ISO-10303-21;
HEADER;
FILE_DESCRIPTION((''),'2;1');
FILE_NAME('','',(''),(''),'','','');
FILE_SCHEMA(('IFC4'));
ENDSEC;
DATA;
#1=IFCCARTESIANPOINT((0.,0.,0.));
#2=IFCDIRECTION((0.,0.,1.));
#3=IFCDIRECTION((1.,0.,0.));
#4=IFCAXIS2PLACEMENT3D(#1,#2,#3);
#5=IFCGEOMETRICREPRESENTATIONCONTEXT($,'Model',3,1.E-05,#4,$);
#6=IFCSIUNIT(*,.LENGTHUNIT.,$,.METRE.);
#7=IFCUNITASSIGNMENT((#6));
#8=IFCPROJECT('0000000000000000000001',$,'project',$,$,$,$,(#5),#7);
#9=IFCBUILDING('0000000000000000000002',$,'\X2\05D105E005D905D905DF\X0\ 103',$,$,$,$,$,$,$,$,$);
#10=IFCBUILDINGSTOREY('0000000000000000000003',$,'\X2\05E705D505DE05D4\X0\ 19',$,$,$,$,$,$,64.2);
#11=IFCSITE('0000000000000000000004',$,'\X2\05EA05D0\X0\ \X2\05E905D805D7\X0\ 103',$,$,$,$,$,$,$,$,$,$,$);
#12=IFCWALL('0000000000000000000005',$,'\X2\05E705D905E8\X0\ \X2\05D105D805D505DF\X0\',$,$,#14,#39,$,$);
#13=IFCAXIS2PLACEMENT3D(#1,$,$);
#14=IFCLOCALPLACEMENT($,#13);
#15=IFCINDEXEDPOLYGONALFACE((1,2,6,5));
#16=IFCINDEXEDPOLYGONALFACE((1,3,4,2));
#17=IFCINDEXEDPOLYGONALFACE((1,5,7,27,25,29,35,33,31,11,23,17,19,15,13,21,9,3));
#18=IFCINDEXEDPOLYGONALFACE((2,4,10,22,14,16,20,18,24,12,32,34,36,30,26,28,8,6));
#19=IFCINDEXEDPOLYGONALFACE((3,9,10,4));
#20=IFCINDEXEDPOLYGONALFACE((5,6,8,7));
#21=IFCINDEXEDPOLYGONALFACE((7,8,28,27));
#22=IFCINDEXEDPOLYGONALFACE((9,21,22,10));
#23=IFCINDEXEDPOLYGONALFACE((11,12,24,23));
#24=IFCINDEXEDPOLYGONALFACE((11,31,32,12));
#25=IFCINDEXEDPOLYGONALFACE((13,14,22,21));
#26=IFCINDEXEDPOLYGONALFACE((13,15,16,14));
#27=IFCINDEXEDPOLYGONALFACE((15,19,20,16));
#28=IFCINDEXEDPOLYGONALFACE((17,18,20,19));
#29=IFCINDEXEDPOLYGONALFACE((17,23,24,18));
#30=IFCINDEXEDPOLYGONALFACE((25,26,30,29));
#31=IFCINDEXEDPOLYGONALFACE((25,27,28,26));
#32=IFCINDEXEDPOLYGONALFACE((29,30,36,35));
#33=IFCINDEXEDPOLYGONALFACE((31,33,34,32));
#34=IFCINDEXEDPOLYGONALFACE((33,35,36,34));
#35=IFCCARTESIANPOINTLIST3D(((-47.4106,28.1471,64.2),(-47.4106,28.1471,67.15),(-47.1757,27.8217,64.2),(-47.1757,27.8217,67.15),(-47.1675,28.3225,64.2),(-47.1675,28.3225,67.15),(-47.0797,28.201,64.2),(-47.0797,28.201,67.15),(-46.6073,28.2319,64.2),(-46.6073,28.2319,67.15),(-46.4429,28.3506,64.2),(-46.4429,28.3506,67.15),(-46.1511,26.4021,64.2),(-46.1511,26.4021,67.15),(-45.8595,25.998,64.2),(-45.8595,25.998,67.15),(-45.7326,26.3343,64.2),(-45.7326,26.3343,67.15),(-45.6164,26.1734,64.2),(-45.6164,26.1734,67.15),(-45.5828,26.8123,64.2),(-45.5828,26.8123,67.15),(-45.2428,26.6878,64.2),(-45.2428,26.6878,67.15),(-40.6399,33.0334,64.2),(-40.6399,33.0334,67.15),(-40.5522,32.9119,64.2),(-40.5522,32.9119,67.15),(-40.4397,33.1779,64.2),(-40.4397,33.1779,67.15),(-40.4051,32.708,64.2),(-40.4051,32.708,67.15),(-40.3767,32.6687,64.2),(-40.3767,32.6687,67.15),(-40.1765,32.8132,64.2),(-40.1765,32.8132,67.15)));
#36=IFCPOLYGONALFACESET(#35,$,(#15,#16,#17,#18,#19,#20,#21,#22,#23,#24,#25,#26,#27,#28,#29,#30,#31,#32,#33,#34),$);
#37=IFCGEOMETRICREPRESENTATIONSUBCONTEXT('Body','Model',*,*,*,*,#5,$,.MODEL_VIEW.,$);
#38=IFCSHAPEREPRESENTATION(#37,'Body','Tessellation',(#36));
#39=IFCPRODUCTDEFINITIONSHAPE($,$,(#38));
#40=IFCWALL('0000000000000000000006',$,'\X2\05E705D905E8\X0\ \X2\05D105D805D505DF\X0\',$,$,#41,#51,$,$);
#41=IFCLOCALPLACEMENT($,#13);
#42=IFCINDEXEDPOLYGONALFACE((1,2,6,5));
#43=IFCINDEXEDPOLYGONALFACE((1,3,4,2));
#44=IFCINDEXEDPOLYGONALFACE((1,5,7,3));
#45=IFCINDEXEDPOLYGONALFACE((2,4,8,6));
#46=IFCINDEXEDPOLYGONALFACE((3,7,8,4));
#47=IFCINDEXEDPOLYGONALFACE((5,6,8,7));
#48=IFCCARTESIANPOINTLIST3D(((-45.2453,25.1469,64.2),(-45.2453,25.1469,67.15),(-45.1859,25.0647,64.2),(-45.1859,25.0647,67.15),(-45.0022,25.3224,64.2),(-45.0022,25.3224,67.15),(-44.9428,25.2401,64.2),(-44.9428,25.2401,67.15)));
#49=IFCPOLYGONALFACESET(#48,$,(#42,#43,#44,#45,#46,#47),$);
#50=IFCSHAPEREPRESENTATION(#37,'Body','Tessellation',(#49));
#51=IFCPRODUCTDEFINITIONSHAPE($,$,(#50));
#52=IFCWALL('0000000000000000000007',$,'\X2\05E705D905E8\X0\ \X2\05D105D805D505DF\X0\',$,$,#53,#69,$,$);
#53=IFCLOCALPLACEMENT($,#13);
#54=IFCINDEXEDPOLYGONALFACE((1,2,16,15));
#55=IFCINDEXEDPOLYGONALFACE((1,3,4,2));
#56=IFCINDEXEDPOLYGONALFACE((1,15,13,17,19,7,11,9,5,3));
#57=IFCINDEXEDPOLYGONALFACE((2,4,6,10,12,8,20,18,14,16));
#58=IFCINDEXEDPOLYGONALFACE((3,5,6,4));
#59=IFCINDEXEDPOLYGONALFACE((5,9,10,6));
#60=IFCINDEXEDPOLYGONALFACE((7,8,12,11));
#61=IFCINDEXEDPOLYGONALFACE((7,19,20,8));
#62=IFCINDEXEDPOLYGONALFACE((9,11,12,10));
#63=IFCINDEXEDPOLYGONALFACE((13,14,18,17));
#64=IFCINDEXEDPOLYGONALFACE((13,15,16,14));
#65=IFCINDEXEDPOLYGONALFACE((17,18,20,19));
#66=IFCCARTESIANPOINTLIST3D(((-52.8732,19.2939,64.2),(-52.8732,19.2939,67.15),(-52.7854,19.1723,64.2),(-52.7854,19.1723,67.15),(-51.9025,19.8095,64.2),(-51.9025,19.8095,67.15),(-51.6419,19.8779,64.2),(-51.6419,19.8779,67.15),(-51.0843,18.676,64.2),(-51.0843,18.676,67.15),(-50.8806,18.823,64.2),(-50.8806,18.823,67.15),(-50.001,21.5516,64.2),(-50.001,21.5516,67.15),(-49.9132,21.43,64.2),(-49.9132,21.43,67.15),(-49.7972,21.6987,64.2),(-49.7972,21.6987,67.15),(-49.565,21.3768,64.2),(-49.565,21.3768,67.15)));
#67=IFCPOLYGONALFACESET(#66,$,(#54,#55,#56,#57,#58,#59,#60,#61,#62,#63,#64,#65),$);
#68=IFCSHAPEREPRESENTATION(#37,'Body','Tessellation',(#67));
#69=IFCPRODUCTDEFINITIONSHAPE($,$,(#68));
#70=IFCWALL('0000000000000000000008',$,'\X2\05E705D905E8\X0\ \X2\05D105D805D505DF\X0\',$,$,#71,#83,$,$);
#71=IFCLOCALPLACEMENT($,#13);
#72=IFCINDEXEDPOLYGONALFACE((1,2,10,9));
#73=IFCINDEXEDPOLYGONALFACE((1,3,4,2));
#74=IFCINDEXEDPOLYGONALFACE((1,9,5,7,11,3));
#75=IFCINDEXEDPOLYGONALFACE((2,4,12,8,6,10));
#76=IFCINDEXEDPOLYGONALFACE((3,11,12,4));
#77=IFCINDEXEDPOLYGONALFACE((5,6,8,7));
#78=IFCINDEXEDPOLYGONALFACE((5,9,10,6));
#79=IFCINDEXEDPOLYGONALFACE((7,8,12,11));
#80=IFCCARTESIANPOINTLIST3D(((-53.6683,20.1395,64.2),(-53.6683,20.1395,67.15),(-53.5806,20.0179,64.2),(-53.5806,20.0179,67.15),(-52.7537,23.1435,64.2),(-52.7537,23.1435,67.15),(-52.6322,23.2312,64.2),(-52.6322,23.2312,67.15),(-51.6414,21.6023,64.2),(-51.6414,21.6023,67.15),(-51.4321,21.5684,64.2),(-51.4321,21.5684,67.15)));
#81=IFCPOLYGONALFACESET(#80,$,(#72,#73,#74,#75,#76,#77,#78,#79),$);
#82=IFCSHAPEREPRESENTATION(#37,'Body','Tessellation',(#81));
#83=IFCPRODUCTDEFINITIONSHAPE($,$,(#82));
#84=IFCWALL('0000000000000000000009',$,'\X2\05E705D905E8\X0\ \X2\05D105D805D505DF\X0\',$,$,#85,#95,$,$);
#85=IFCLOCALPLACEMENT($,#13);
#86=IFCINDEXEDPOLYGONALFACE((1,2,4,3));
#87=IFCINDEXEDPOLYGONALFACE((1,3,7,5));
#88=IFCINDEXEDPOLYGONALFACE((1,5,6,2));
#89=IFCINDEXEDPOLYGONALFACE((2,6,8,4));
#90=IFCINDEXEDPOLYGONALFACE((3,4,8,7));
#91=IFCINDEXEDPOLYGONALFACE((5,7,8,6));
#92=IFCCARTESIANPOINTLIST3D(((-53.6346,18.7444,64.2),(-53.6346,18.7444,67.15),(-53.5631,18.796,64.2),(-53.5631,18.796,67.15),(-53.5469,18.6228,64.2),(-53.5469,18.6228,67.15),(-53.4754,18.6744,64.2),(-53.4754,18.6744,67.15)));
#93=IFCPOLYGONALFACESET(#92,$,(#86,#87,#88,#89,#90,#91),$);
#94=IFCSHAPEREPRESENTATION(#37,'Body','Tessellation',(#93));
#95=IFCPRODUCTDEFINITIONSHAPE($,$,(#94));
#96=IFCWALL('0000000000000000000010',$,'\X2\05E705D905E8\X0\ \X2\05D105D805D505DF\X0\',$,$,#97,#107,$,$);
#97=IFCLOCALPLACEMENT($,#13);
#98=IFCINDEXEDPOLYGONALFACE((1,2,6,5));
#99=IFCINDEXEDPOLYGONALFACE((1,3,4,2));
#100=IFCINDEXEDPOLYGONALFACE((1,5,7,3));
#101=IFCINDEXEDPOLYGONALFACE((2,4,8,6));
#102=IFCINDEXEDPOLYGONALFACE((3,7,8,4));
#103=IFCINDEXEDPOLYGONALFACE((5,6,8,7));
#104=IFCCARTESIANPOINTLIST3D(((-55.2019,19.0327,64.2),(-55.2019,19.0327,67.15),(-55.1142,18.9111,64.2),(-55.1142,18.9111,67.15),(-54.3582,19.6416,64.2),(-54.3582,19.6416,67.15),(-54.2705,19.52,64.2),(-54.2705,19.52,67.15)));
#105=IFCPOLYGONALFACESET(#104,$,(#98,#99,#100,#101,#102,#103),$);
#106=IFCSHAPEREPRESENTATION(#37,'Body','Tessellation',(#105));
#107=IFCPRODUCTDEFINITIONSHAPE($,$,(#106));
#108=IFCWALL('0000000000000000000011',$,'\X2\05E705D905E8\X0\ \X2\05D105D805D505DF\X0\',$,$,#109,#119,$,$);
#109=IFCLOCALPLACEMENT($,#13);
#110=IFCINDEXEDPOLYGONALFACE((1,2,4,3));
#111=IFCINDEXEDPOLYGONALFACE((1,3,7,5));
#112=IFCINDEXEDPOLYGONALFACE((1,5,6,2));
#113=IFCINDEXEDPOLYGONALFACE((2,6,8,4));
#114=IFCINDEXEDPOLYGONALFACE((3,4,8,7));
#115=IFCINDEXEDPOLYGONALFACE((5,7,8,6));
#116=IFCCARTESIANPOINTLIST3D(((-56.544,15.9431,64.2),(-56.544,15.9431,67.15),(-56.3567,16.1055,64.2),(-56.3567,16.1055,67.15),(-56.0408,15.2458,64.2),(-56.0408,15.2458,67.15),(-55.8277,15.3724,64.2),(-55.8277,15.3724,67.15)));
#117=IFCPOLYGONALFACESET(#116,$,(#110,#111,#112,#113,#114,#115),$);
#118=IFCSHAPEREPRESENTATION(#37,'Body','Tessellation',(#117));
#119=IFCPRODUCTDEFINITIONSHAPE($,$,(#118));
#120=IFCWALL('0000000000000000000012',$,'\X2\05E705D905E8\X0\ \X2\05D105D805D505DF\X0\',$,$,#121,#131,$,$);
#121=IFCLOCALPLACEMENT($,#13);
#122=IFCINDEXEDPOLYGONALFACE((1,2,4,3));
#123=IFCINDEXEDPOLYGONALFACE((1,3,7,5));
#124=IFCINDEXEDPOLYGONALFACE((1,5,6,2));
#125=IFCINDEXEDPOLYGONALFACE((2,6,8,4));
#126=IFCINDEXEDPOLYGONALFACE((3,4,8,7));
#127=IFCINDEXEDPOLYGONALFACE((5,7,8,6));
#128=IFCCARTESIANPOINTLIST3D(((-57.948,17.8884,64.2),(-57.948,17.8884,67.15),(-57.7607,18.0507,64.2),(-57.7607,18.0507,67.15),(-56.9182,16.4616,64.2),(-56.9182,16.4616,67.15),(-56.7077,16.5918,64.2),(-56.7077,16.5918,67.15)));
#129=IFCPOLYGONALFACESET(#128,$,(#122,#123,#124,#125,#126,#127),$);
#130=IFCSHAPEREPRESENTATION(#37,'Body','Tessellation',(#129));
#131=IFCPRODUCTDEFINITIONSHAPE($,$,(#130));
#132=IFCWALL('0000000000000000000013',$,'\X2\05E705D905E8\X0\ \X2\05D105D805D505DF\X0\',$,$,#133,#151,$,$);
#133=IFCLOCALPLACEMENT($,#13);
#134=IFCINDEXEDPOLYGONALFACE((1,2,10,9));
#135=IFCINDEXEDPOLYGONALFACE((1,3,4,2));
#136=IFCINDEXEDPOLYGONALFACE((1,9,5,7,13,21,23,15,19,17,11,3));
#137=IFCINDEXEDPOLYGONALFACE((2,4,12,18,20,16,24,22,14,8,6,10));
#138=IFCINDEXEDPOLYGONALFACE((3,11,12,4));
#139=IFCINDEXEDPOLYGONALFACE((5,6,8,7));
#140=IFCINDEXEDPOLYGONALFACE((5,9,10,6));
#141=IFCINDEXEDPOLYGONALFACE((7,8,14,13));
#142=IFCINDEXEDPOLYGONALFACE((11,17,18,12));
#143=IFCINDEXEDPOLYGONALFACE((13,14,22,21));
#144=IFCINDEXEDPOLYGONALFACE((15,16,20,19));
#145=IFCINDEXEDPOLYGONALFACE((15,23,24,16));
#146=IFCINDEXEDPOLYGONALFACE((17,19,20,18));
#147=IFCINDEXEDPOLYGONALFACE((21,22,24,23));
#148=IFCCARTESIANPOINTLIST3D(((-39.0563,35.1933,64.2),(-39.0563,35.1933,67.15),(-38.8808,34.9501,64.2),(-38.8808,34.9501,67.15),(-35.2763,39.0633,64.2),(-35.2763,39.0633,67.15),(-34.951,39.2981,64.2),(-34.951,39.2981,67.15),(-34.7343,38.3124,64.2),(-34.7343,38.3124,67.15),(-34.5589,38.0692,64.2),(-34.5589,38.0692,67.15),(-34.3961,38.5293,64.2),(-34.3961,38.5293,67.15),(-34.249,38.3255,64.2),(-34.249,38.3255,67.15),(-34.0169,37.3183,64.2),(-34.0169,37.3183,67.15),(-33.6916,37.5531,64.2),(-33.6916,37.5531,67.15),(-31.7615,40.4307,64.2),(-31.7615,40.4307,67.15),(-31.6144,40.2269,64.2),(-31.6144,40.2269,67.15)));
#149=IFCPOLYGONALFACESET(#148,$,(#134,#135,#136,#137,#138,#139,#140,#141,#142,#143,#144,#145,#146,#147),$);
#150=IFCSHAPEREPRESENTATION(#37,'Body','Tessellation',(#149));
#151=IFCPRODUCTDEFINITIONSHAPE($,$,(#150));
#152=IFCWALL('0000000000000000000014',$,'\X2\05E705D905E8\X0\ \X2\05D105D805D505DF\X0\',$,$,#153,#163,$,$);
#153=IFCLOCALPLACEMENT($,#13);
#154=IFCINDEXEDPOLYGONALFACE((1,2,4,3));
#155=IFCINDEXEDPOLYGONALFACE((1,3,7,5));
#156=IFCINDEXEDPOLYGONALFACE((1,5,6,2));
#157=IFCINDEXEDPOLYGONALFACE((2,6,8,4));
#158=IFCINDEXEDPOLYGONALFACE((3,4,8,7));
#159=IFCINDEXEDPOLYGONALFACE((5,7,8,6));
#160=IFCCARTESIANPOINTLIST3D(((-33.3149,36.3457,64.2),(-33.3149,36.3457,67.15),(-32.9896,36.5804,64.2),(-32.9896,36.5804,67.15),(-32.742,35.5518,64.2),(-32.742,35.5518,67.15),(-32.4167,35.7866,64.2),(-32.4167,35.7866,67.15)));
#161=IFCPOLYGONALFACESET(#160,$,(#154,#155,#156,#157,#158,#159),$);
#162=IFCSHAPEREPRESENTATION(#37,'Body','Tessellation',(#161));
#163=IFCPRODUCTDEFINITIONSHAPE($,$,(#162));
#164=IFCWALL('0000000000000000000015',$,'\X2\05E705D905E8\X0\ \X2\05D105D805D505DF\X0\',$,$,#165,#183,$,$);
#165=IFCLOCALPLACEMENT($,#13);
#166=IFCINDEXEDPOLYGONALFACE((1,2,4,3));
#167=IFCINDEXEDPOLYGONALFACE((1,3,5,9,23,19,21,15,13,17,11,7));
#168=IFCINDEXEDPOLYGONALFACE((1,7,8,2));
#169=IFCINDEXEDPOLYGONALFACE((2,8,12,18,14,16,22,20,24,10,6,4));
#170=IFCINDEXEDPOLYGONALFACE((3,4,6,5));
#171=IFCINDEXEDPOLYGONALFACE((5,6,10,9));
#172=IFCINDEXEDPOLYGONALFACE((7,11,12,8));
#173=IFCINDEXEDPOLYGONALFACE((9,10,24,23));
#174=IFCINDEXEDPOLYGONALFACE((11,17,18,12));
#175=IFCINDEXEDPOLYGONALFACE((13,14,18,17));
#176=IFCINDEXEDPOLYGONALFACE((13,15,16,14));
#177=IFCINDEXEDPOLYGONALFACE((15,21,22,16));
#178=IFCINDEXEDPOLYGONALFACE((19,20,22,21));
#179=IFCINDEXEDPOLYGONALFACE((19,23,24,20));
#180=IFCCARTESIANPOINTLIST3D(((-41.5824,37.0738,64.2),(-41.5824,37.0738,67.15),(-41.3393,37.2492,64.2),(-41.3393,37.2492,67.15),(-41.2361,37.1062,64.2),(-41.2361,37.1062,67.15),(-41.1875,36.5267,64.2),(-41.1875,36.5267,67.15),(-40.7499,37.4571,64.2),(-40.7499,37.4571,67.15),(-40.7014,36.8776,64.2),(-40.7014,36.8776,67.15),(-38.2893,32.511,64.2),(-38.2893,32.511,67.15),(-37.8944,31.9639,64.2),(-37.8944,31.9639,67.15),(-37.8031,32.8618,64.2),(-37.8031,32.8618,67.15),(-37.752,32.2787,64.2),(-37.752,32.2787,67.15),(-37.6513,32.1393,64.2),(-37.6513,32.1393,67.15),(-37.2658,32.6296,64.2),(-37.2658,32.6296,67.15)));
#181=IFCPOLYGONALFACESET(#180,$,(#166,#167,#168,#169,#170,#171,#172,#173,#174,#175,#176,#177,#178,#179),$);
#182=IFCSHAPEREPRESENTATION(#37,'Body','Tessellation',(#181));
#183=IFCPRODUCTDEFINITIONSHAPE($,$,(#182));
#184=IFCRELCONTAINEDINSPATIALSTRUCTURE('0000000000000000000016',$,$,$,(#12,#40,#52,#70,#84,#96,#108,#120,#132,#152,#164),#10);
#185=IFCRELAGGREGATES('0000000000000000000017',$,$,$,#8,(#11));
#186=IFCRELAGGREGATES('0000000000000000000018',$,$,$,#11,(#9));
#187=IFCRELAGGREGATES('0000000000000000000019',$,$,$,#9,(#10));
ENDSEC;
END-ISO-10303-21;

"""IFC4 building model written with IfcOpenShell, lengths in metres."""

from ifc_helpers import new_model, si_unit, frame, origin_with_axes, context, subcontext, project, spatial, polyline, outline, extrude, element, save


model = new_model("IFC4")

# Units and contexts
model_context = context("Model", 3, precision=1e-05, world=origin_with_axes())
body_context = subcontext(model_context, "Body", "Model", "MODEL_VIEW")
ifc_project = project(units=[si_unit("LENGTHUNIT", "METRE")], contexts=[model_context])

# Site, building, storey
site = spatial("IfcSite", under=ifc_project, Name="תא שטח 103")
building = spatial("IfcBuilding", under=site, Name="בניין 103")
storey = spatial("IfcBuildingStorey", under=building, Name="קומה 19", Elevation=64.2)

# Walls
element("IfcWall", 1, inside=storey, Name="קיר בטון", context=body_context, shape_type="SweptSolid", body=[
    extrude(outline(polyline([(-45.6164, 26.1734), (-45.8595, 25.998), (-46.1511, 26.4021), (-45.5828, 26.8123), (-46.6073, 28.2319), (-47.1757, 27.8217), (-47.4106, 28.1471), (-47.1675, 28.3225), (-47.0797, 28.201), (-40.5522, 32.9119), (-40.6399, 33.0334), (-40.4397, 33.1779), (-40.1765, 32.8132), (-40.3767, 32.6687), (-40.4051, 32.708), (-46.4429, 28.3506), (-45.2428, 26.6878), (-45.7326, 26.3343), (-45.6164, 26.1734)])), frame((0.0, 0.0, 64.2)), (0.0, 0.0, 1.0), 2.95),
])
element("IfcWall", 2, inside=storey, Name="קיר בטון", context=body_context, shape_type="SweptSolid", body=[
    extrude(outline(polyline([(-45.2453, 25.1469), (-45.0022, 25.3224), (-44.9428, 25.2401), (-45.1859, 25.0647), (-45.2453, 25.1469)])), frame((0.0, 0.0, 64.2)), (0.0, 0.0, 1.0), 2.95),
])
element("IfcWall", 3, inside=storey, Name="קיר בטון", context=body_context, shape_type="SweptSolid", body=[
    extrude(outline(polyline([(-51.6419, 19.8779), (-50.8806, 18.823), (-51.0843, 18.676), (-51.9025, 19.8095), (-52.7854, 19.1723), (-52.8732, 19.2939), (-49.9132, 21.43), (-50.001, 21.5516), (-49.7972, 21.6987), (-49.565, 21.3768), (-51.6419, 19.8779)])), frame((0.0, 0.0, 64.2)), (0.0, 0.0, 1.0), 2.95),
])
element("IfcWall", 4, inside=storey, Name="קיר בטון", context=body_context, shape_type="SweptSolid", body=[
    extrude(outline(polyline([(-53.5806, 20.0179), (-53.6683, 20.1395), (-51.6414, 21.6023), (-52.7537, 23.1435), (-52.6322, 23.2312), (-51.4321, 21.5684), (-53.5806, 20.0179)])), frame((0.0, 0.0, 64.2)), (0.0, 0.0, 1.0), 2.95),
])
element("IfcWall", 5, inside=storey, Name="קיר בטון", context=body_context, shape_type="SweptSolid", body=[
    extrude(outline(polyline([(-53.5469, 18.6228), (-53.6346, 18.7444), (-53.5631, 18.796), (-53.4754, 18.6744), (-53.5469, 18.6228)])), frame((0.0, 0.0, 64.2)), (0.0, 0.0, 1.0), 2.95),
])
element("IfcWall", 6, inside=storey, Name="קיר בטון", context=body_context, shape_type="SweptSolid", body=[
    extrude(outline(polyline([(-54.3582, 19.6416), (-54.2705, 19.52), (-55.1142, 18.9111), (-55.2019, 19.0327), (-54.3582, 19.6416)])), frame((0.0, 0.0, 64.2)), (0.0, 0.0, 1.0), 2.95),
])
element("IfcWall", 7, inside=storey, Name="קיר בטון", context=body_context, shape_type="SweptSolid", body=[
    extrude(outline(polyline([(-56.0408, 15.2458), (-56.544, 15.9431), (-56.3567, 16.1055), (-55.8277, 15.3724), (-56.0408, 15.2458)])), frame((0.0, 0.0, 64.2)), (0.0, 0.0, 1.0), 2.95),
])
element("IfcWall", 8, inside=storey, Name="קיר בטון", context=body_context, shape_type="SweptSolid", body=[
    extrude(outline(polyline([(-56.9182, 16.4616), (-57.948, 17.8884), (-57.7607, 18.0507), (-56.7077, 16.5918), (-56.9182, 16.4616)])), frame((0.0, 0.0, 64.2)), (0.0, 0.0, 1.0), 2.95),
])
element("IfcWall", 9, inside=storey, Name="קיר בטון", context=body_context, shape_type="SweptSolid", body=[
    extrude(outline(polyline([(-31.7615, 40.4307), (-31.6144, 40.2269), (-34.249, 38.3255), (-33.6916, 37.5531), (-34.0169, 37.3183), (-34.5589, 38.0692), (-38.8808, 34.9501), (-39.0563, 35.1933), (-34.7343, 38.3124), (-35.2763, 39.0633), (-34.951, 39.2981), (-34.3961, 38.5293), (-31.7615, 40.4307)])), frame((0.0, 0.0, 64.2)), (0.0, 0.0, 1.0), 2.95),
])
element("IfcWall", 10, inside=storey, Name="קיר בטון", context=body_context, shape_type="SweptSolid", body=[
    extrude(outline(polyline([(-32.9896, 36.5804), (-32.4167, 35.7866), (-32.742, 35.5518), (-33.3149, 36.3457), (-32.9896, 36.5804)])), frame((0.0, 0.0, 64.2)), (0.0, 0.0, 1.0), 2.95),
])
element("IfcWall", 11, inside=storey, Name="קיר בטון", context=body_context, shape_type="SweptSolid", body=[
    extrude(outline(polyline([(-37.8031, 32.8618), (-40.7014, 36.8776), (-41.1875, 36.5267), (-41.5824, 37.0738), (-41.3393, 37.2492), (-41.2361, 37.1062), (-40.7499, 37.4571), (-37.2658, 32.6296), (-37.752, 32.2787), (-37.6513, 32.1393), (-37.8944, 31.9639), (-38.2893, 32.511), (-37.8031, 32.8618)])), frame((0.0, 0.0, 64.2)), (0.0, 0.0, 1.0), 2.95),
])

save(model, "model.ifc")
